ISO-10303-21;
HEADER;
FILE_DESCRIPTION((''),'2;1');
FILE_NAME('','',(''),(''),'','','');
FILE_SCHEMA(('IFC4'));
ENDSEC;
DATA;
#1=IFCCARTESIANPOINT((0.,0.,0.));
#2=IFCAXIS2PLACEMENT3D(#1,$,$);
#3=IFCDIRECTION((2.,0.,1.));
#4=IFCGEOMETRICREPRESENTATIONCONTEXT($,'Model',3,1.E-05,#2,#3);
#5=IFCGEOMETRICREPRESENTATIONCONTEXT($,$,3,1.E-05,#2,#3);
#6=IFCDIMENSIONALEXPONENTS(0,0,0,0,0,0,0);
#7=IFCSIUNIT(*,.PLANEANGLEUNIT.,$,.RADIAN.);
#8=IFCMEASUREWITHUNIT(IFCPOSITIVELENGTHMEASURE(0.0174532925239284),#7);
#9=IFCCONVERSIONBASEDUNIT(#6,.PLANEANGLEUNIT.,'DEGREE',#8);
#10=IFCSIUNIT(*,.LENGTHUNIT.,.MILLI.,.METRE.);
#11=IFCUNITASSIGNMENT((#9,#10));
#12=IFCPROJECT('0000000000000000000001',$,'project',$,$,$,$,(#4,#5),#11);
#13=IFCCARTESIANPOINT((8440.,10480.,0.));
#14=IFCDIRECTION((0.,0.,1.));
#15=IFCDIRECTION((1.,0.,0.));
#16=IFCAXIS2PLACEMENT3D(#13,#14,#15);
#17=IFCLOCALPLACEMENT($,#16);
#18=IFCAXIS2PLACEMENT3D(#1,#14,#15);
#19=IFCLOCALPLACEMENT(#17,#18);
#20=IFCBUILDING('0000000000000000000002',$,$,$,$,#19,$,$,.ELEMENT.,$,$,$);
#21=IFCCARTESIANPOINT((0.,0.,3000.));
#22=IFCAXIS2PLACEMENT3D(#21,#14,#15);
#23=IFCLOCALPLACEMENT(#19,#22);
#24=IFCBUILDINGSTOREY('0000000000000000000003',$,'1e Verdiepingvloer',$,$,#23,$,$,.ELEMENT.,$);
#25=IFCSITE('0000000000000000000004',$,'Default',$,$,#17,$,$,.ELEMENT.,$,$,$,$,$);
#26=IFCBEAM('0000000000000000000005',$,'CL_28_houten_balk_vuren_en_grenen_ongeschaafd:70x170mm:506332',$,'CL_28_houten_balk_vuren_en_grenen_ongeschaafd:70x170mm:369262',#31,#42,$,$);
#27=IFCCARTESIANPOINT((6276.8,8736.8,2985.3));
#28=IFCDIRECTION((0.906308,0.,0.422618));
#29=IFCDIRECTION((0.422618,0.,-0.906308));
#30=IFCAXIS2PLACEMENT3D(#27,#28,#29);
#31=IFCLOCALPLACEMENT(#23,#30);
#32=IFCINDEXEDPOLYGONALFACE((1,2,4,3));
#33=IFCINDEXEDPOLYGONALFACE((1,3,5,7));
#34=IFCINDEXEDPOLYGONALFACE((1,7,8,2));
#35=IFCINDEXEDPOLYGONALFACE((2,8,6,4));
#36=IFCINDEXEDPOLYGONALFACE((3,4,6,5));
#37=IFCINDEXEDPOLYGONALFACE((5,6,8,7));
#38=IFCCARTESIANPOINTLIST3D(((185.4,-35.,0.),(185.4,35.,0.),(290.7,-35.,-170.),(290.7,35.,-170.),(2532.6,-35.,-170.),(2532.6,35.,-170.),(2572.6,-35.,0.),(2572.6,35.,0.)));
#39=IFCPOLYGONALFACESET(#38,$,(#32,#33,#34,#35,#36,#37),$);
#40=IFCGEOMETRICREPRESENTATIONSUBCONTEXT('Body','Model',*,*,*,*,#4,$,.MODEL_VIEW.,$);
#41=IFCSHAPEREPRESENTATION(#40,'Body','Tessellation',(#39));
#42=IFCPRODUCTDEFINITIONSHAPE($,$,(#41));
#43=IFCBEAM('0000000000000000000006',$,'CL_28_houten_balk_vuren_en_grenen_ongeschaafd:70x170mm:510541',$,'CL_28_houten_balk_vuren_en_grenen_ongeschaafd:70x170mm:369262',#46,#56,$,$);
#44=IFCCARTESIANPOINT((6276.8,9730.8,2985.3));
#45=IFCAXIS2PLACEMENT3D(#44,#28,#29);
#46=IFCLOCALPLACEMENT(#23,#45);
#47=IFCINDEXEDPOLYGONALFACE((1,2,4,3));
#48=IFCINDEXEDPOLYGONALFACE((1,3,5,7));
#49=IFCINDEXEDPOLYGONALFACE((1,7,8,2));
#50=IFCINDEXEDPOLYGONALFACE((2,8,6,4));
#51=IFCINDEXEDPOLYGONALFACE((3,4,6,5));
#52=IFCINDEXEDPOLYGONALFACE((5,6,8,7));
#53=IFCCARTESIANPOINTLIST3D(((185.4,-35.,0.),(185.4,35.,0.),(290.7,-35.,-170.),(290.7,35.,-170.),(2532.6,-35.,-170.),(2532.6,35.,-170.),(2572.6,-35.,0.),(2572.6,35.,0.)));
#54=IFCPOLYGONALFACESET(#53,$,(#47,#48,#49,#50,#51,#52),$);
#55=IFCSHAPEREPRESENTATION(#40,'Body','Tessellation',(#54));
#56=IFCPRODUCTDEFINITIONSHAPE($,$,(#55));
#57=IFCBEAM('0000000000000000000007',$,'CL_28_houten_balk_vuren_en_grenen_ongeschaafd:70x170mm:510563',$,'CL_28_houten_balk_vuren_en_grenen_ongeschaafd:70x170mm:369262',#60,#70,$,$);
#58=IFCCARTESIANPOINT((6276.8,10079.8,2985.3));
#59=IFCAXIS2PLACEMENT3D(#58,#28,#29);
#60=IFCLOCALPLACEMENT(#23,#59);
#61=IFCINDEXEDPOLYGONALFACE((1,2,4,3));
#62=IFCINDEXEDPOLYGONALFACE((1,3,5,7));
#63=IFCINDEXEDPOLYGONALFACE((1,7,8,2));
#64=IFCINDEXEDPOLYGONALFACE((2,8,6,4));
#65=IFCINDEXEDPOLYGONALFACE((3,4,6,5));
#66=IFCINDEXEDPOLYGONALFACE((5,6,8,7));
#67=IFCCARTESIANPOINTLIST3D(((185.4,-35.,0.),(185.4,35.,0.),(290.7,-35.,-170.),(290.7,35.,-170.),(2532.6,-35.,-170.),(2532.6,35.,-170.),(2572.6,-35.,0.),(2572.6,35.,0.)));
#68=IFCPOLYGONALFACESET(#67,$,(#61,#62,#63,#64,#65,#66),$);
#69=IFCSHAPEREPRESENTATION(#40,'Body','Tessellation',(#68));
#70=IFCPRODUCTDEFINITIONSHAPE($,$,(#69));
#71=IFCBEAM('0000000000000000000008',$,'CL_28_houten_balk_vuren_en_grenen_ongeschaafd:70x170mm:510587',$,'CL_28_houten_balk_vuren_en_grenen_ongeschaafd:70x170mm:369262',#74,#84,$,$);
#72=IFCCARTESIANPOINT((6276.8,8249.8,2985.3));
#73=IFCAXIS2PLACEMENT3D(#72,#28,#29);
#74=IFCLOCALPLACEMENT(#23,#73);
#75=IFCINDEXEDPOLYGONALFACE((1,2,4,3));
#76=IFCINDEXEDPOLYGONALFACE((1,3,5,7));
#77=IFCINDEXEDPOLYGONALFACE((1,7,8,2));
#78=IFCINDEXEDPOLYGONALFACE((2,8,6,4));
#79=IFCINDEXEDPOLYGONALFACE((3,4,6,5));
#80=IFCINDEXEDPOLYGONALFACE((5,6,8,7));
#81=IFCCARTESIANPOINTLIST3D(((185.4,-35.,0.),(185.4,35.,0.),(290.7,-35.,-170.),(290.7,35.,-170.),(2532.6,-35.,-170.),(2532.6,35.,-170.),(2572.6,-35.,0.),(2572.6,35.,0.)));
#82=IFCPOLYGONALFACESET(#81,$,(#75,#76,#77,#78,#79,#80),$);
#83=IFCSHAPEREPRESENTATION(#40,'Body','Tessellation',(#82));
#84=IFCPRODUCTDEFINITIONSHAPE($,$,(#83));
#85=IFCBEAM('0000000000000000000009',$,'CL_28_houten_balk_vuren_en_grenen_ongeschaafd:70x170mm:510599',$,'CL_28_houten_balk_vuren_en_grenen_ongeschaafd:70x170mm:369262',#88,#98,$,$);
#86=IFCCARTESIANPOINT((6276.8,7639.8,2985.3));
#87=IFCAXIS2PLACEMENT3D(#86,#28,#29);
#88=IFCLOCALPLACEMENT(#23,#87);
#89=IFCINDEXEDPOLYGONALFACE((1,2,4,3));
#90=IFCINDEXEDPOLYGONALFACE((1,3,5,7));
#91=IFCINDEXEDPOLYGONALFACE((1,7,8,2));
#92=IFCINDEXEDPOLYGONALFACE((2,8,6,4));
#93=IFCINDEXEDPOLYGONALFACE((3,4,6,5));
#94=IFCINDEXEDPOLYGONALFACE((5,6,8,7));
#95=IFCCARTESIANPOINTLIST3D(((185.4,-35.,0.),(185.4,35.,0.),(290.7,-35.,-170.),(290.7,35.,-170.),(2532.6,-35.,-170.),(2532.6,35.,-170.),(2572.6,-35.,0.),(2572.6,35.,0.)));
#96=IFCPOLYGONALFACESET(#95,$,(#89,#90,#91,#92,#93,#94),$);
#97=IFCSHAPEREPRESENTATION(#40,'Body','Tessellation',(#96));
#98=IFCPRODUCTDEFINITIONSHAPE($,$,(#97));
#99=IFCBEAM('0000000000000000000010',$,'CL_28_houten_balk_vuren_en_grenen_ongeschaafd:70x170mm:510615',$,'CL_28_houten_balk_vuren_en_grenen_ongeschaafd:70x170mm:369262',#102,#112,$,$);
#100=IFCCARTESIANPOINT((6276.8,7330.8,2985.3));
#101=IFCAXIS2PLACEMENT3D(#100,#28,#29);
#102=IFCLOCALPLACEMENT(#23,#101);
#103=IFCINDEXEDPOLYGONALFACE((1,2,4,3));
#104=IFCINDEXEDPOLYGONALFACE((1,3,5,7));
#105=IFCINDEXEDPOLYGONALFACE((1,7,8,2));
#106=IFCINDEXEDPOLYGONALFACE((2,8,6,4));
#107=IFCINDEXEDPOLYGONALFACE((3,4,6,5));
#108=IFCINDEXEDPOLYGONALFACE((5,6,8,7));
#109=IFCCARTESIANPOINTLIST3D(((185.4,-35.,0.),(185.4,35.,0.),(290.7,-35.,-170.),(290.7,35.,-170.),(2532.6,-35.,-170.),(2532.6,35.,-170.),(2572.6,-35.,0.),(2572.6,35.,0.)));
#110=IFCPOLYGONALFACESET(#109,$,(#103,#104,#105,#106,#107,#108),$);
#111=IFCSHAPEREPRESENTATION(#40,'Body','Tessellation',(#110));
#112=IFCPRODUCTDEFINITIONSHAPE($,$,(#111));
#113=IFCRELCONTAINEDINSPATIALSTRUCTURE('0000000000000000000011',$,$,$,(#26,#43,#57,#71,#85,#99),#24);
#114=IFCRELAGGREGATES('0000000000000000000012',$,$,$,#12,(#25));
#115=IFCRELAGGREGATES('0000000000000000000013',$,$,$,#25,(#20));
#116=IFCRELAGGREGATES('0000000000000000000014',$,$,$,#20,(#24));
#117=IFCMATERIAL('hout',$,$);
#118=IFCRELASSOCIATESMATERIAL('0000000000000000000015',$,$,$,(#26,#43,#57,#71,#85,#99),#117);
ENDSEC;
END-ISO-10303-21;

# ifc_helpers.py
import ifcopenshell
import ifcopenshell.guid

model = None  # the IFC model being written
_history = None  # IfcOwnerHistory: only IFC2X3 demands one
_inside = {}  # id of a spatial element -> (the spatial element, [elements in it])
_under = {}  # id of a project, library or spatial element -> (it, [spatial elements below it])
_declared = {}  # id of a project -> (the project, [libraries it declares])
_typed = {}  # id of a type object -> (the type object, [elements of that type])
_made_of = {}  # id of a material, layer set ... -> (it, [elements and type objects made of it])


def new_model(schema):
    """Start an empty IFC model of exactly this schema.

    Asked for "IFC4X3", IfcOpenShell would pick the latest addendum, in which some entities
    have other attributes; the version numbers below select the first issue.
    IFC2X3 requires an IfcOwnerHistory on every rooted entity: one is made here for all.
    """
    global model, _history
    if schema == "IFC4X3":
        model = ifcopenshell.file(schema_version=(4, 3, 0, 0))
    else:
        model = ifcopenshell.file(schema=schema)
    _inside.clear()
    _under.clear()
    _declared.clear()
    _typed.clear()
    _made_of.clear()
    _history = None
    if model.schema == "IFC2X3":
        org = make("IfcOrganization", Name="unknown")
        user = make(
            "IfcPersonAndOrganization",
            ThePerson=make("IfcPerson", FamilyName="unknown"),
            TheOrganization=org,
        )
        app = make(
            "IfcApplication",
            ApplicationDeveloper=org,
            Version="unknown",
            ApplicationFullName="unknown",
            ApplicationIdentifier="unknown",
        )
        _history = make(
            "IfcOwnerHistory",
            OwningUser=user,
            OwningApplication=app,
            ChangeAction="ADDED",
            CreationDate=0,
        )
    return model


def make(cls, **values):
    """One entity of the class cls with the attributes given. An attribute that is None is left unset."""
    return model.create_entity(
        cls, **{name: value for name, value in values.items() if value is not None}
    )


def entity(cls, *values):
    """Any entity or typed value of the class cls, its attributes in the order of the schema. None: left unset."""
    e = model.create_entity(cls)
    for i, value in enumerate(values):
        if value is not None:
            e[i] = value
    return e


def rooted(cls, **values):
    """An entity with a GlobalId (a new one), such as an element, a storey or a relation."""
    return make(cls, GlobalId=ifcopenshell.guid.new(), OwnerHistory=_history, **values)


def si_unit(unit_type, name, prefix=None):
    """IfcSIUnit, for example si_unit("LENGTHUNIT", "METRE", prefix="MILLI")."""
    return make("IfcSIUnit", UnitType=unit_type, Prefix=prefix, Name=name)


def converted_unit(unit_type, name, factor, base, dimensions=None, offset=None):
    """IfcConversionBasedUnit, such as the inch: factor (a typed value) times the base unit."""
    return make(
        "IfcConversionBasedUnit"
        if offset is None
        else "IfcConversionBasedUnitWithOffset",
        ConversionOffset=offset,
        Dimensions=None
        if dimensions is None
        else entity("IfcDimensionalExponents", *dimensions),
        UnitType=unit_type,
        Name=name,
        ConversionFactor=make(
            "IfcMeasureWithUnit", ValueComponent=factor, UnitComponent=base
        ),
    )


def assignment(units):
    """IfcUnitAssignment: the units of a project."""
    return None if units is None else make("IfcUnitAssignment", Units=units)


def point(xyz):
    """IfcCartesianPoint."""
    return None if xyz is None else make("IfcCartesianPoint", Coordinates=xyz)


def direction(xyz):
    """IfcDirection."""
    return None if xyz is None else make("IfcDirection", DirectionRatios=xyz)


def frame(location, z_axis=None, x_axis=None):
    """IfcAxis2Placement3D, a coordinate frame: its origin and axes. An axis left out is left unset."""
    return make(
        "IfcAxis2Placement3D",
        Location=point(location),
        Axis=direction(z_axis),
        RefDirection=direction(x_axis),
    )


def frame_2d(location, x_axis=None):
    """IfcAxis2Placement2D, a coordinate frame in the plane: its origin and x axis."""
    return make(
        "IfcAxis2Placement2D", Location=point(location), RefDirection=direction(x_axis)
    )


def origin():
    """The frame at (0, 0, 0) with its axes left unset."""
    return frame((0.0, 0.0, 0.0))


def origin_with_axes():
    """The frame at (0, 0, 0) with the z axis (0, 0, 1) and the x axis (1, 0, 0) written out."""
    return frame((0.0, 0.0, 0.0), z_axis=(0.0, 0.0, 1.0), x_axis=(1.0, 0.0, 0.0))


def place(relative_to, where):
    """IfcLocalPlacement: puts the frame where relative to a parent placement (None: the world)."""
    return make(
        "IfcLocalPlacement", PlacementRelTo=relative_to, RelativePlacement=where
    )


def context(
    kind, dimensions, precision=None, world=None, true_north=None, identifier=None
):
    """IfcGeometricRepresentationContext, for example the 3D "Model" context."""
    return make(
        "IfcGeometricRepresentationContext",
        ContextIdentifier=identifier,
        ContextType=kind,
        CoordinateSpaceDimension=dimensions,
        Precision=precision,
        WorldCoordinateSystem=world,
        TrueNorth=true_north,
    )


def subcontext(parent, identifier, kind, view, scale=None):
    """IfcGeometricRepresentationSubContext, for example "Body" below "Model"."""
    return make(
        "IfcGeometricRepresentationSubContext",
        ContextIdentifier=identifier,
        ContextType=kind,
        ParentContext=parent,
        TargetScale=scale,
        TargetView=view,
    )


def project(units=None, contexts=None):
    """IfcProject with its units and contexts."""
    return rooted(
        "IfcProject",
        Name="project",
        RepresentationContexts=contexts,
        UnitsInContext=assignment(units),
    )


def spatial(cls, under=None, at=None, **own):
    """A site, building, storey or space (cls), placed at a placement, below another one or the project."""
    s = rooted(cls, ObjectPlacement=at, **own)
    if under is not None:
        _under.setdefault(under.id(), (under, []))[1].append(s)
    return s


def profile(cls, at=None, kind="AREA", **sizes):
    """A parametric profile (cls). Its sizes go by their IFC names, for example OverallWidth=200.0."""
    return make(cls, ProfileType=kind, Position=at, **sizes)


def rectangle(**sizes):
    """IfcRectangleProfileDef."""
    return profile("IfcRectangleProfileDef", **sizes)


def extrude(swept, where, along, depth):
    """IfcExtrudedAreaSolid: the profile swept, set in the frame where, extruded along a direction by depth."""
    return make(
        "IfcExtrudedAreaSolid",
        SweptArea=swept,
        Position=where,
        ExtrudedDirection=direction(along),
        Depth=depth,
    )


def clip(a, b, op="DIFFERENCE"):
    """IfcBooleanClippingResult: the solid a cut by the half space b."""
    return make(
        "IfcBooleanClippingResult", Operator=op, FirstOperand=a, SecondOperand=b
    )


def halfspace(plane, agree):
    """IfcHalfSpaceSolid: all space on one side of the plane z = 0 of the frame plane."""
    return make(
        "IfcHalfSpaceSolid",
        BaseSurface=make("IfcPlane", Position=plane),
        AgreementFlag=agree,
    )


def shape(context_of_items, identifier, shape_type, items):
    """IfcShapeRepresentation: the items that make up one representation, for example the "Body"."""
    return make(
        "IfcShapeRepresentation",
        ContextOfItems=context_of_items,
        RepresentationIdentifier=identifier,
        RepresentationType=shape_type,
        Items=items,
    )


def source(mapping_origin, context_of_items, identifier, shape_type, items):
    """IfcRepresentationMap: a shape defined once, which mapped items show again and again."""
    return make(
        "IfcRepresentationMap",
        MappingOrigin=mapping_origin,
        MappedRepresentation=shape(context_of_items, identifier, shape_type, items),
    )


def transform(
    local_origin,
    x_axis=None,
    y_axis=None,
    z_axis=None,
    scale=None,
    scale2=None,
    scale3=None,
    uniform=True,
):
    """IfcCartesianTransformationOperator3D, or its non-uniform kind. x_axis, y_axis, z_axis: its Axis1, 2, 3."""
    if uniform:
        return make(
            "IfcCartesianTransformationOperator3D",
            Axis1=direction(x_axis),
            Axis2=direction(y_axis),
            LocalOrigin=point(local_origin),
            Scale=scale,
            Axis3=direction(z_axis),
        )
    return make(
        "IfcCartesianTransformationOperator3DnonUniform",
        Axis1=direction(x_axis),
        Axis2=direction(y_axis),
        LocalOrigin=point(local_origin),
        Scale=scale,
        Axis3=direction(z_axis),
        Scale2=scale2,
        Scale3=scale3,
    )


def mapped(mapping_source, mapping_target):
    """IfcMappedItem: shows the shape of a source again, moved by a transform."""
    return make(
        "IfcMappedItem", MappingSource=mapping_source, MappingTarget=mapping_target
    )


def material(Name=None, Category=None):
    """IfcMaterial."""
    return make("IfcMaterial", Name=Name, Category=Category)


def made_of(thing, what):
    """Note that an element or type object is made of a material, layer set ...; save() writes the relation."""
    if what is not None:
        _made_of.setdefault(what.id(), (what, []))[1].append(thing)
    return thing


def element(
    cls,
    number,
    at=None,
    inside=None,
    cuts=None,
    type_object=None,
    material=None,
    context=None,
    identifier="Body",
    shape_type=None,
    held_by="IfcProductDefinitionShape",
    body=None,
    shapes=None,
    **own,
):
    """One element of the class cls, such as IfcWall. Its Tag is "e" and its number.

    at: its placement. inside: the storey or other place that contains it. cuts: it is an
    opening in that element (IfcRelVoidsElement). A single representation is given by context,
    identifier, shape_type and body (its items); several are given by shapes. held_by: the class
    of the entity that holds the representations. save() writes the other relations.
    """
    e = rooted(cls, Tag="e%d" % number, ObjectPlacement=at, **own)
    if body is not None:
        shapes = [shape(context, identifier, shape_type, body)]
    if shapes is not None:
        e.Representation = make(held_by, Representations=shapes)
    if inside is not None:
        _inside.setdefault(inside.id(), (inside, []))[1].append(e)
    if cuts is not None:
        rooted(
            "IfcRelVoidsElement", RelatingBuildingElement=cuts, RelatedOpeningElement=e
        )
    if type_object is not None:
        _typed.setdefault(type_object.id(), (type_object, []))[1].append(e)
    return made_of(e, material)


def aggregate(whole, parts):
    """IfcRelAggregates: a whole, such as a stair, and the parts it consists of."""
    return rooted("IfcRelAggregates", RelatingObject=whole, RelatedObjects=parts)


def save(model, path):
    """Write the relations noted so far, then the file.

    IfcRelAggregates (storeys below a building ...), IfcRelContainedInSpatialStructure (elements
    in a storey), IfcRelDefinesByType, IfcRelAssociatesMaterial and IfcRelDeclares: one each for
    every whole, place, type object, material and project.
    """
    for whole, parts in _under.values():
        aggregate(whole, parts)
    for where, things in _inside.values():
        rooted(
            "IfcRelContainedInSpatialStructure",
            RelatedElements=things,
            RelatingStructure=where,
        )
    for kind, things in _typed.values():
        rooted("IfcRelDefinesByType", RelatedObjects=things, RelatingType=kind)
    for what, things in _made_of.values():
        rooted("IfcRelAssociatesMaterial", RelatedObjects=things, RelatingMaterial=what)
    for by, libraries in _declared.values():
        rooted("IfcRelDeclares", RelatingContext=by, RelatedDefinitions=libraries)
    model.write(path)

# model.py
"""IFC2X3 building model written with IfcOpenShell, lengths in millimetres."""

from ifc_helpers import new_model, entity, si_unit, converted_unit, direction, frame, frame_2d, origin, origin_with_axes, place, context, subcontext, project, spatial, rectangle, extrude, clip, halfspace, source, transform, mapped, material, element, save


model = new_model("IFC2X3")

# Units and contexts
model_context = context("Model", 3, precision=1e-05, world=origin(), true_north=direction((2.0, 0.0, 1.0)))
context_of_model = context(None, 3, precision=1e-05, world=origin(), true_north=direction((2.0, 0.0, 1.0)))
body_context = subcontext(model_context, "Body", "Model", "MODEL_VIEW")
ifc_project = project(units=[converted_unit("PLANEANGLEUNIT", "DEGREE", entity("IfcPositiveLengthMeasure", 0.0174532925239284), si_unit("PLANEANGLEUNIT", "RADIAN"), dimensions=[0, 0, 0, 0, 0, 0, 0]), si_unit("LENGTHUNIT", "METRE", prefix="MILLI")], contexts=[model_context, context_of_model])

# Site, building, storey
site_placement = place(None, frame((8440.0, 10480.0, 0.0), z_axis=(0.0, 0.0, 1.0), x_axis=(1.0, 0.0, 0.0)))
site = spatial("IfcSite", under=ifc_project, at=site_placement, Name="Default", CompositionType="ELEMENT")
building_placement = place(site_placement, origin_with_axes())
building = spatial("IfcBuilding", under=site, at=building_placement, CompositionType="ELEMENT")
storey_placement = place(building_placement, frame((0.0, 0.0, 3000.0), z_axis=(0.0, 0.0, 1.0), x_axis=(1.0, 0.0, 0.0)))
storey = spatial("IfcBuildingStorey", under=building, at=storey_placement, Name="1e Verdiepingvloer", CompositionType="ELEMENT")

# Beams
ifc_material_1 = material(Name="hout")
shared_shape_1 = source(origin(), body_context, "Body", "Clipping", [
    clip(clip(extrude(rectangle(XDim=170.0, YDim=70.0, at=frame_2d((0.0, 0.0), x_axis=(1.0, 0.0))), frame((185.4, 0.0, -85.0), z_axis=(1.0, 0.0, 0.0), x_axis=(0.0, 0.0, -1.0)), (0.0, 0.0, 1.0), 2387.2), halfspace(frame((290.7, -947.7, -170.0), z_axis=(-0.850088, 0.0, -0.52664), x_axis=(-0.52664, 0.0, 0.850088)), False)), halfspace(frame((2532.6, -947.7, -170.0), z_axis=(0.973348, 0.0, -0.229334), x_axis=(0.229334, 0.0, 0.973348)), False)),
])
for number, where, z_axis, x_axis, name in (
    (1, (6276.8, 8736.8, 2985.3), (0.906308, 0.0, 0.422618), (0.422618, 0.0, -0.906308), "CL_28_houten_balk_vuren_en_grenen_ongeschaafd:70x170mm:506332"),
    (2, (6276.8, 9730.8, 2985.3), (0.906308, 0.0, 0.422618), (0.422618, 0.0, -0.906308), "CL_28_houten_balk_vuren_en_grenen_ongeschaafd:70x170mm:510541"),
    (3, (6276.8, 10079.8, 2985.3), (0.906308, 0.0, 0.422618), (0.422618, 0.0, -0.906308), "CL_28_houten_balk_vuren_en_grenen_ongeschaafd:70x170mm:510563"),
):
    element("IfcBeam", number, at=place(storey_placement, frame(where, z_axis=z_axis, x_axis=x_axis)), inside=storey, material=ifc_material_1, Name=name, ObjectType="CL_28_houten_balk_vuren_en_grenen_ongeschaafd:70x170mm:369262", context=body_context, shape_type="MappedRepresentation", body=[
        mapped(shared_shape_1, transform((0.0, 0.0, 0.0))),
    ])
shared_shape_2 = source(origin(), body_context, "Body", "Clipping", [
    clip(clip(extrude(rectangle(XDim=170.0, YDim=70.0, at=frame_2d((0.0, 0.0), x_axis=(1.0, 0.0))), frame((185.4, 0.0, -85.0), z_axis=(1.0, 0.0, 0.0), x_axis=(0.0, 0.0, -1.0)), (0.0, 0.0, 1.0), 2387.2), halfspace(frame((2532.6, -2690.7, -170.0), z_axis=(0.973348, 0.0, -0.229334), x_axis=(0.229334, 0.0, 0.973348)), False)), halfspace(frame((290.7, -2690.7, -170.0), z_axis=(-0.850088, 0.0, -0.52664), x_axis=(-0.52664, 0.0, 0.850088)), False)),
])
for number, where, z_axis, x_axis, name in (
    (4, (6276.8, 8249.8, 2985.3), (0.906308, 0.0, 0.422618), (0.422618, 0.0, -0.906308), "CL_28_houten_balk_vuren_en_grenen_ongeschaafd:70x170mm:510587"),
    (5, (6276.8, 7639.8, 2985.3), (0.906308, 0.0, 0.422618), (0.422618, 0.0, -0.906308), "CL_28_houten_balk_vuren_en_grenen_ongeschaafd:70x170mm:510599"),
    (6, (6276.8, 7330.8, 2985.3), (0.906308, 0.0, 0.422618), (0.422618, 0.0, -0.906308), "CL_28_houten_balk_vuren_en_grenen_ongeschaafd:70x170mm:510615"),
):
    element("IfcBeam", number, at=place(storey_placement, frame(where, z_axis=z_axis, x_axis=x_axis)), inside=storey, material=ifc_material_1, Name=name, ObjectType="CL_28_houten_balk_vuren_en_grenen_ongeschaafd:70x170mm:369262", context=body_context, shape_type="MappedRepresentation", body=[
        mapped(shared_shape_2, transform((0.0, 0.0, 0.0))),
    ])

save(model, "model.ifc")
